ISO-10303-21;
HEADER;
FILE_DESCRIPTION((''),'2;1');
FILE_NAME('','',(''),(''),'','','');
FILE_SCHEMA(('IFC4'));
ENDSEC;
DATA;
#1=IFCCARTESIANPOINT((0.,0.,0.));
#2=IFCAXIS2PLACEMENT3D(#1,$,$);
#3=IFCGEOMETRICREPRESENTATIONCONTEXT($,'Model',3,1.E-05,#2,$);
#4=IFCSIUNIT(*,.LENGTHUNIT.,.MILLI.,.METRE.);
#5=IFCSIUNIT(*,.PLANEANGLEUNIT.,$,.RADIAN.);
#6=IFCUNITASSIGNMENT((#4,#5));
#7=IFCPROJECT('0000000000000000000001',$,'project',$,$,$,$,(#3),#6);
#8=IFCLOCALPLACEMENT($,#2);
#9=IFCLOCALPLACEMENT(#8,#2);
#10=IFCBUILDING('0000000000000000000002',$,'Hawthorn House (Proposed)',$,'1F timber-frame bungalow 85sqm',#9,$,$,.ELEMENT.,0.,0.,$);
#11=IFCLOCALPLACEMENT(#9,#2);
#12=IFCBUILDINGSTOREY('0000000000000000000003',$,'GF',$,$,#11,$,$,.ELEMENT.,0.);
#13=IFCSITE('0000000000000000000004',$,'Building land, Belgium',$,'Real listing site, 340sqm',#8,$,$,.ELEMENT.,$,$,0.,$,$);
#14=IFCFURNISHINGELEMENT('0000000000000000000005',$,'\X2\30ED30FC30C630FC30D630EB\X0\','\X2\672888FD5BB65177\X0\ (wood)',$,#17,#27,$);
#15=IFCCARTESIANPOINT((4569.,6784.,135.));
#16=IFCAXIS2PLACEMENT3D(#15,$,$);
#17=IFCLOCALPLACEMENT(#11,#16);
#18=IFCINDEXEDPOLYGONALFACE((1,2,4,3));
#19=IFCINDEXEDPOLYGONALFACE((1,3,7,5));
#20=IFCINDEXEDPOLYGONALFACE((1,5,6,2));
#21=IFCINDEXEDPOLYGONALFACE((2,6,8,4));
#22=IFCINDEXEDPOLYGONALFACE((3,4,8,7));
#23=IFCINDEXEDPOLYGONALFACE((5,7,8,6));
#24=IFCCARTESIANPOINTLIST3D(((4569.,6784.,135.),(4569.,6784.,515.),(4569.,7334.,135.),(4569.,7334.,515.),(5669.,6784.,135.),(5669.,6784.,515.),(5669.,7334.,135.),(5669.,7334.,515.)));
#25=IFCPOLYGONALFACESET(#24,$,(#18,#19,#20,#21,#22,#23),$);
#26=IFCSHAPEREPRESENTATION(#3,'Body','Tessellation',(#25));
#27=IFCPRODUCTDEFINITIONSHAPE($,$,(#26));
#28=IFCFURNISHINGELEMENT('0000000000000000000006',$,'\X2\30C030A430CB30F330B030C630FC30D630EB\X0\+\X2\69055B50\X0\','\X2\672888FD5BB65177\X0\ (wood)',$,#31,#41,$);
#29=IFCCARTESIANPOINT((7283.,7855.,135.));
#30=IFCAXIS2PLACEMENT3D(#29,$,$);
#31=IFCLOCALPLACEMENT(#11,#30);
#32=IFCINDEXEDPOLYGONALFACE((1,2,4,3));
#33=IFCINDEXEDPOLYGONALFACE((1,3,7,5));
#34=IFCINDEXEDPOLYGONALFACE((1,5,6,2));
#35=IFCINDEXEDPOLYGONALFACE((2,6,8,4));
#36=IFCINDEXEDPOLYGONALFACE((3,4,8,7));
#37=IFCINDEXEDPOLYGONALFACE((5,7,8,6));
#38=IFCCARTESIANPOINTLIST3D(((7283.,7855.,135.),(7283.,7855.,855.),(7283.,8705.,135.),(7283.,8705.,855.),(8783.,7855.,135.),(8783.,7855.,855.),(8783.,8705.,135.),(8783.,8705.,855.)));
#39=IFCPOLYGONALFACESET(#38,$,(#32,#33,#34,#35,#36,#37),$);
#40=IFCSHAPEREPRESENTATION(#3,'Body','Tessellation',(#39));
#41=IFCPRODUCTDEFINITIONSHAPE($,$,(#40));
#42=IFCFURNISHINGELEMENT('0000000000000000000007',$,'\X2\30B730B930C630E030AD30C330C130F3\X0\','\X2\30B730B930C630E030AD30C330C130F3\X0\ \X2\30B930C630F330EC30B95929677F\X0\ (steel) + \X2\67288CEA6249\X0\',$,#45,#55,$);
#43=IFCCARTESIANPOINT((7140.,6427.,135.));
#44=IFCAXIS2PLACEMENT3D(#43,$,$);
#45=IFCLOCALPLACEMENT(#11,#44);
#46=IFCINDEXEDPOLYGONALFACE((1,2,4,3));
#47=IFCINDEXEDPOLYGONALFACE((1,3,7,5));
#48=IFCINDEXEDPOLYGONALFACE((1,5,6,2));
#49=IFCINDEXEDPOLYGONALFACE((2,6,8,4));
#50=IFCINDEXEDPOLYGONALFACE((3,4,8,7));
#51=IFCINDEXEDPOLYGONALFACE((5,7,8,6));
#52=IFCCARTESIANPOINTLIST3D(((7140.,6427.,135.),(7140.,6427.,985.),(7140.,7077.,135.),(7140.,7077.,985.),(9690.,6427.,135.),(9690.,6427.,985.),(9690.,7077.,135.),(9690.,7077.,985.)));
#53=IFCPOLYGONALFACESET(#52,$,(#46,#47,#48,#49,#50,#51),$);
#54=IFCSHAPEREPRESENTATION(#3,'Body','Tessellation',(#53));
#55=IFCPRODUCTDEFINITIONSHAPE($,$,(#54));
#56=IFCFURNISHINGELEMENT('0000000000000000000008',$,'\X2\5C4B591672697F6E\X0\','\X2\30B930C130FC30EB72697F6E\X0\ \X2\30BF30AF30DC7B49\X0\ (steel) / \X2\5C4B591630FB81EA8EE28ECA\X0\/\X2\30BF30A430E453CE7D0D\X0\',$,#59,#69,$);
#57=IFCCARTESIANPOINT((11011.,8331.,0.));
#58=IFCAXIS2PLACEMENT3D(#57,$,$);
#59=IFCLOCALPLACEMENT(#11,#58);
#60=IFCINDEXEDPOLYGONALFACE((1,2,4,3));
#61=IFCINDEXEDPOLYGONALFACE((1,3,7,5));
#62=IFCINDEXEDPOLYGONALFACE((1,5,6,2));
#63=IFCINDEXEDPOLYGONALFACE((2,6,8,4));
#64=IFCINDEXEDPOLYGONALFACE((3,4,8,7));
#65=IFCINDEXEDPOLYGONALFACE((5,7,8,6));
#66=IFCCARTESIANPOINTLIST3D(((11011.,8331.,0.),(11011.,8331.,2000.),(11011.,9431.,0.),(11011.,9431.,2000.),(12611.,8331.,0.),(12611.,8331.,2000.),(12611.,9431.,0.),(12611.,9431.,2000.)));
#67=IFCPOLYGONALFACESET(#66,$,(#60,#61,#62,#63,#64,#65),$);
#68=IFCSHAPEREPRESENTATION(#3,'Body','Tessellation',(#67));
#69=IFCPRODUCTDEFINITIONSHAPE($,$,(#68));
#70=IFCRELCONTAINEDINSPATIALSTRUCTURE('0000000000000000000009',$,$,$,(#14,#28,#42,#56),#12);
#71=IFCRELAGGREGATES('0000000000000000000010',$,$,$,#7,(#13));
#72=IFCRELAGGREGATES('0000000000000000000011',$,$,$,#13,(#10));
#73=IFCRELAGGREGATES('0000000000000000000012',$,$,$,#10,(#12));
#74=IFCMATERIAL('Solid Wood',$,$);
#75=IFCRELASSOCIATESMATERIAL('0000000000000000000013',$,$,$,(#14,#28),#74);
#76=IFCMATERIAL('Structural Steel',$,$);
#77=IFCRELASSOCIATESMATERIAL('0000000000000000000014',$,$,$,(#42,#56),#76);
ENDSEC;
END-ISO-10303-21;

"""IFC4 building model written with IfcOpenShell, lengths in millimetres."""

from ifc_helpers import new_model, si_unit, frame, frame_2d, origin, place, context, project, spatial, rectangle, extrude, material, element, save


model = new_model("IFC4")

# Units and contexts
model_context = context("Model", 3, precision=1e-05, world=origin())
ifc_project = project(units=[si_unit("LENGTHUNIT", "METRE", prefix="MILLI"), si_unit("PLANEANGLEUNIT", "RADIAN")], contexts=[model_context])

# Site, building, storey
site_placement = place(None, origin())
site = spatial("IfcSite", under=ifc_project, at=site_placement, Name="Building land, Belgium", ObjectType="Real listing site, 340sqm", CompositionType="ELEMENT", RefElevation=0.0)
building_placement = place(site_placement, origin())
building = spatial("IfcBuilding", under=site, at=building_placement, Name="Hawthorn House (Proposed)", ObjectType="1F timber-frame bungalow 85sqm", CompositionType="ELEMENT", ElevationOfRefHeight=0.0, ElevationOfTerrain=0.0)
storey_placement = place(building_placement, origin())
storey = spatial("IfcBuildingStorey", under=building, at=storey_placement, Name="GF", CompositionType="ELEMENT", Elevation=0.0)

# Shared definitions
ifc_material_1 = material(Name="Solid Wood")

# Shared definitions
ifc_material_2 = material(Name="Structural Steel")

# Furnishing elements
furnishing_1_placement = place(storey_placement, frame((4569.0, 6784.0, 135.0)))
element("IfcFurnishingElement", 1, at=furnishing_1_placement, inside=storey, material=ifc_material_1, Name="ローテーブル", Description="木製家具 (wood)", context=model_context, shape_type="SweptSolid", body=[
    extrude(rectangle(XDim=1100.0, YDim=550.0, at=frame_2d((550.0, 275.0))), frame((4569.0, 6784.0, 135.0)), (0.0, 0.0, 1.0), 380.0),
])
furnishing_2_placement = place(storey_placement, frame((7283.0, 7855.0, 135.0)))
element("IfcFurnishingElement", 2, at=furnishing_2_placement, inside=storey, material=ifc_material_1, Name="ダイニングテーブル+椅子", Description="木製家具 (wood)", context=model_context, shape_type="SweptSolid", body=[
    extrude(rectangle(XDim=1500.0, YDim=850.0, at=frame_2d((750.0, 425.0))), frame((7283.0, 7855.0, 135.0)), (0.0, 0.0, 1.0), 720.0),
])
furnishing_3_placement = place(storey_placement, frame((7140.0, 6427.0, 135.0)))
element("IfcFurnishingElement", 3, at=furnishing_3_placement, inside=storey, material=ifc_material_2, Name="システムキッチン", Description="システムキッチン ステンレス天板 (steel) + 木質扉", context=model_context, shape_type="SweptSolid", body=[
    extrude(rectangle(XDim=2550.0, YDim=650.0, at=frame_2d((1275.0, 325.0))), frame((7140.0, 6427.0, 135.0)), (0.0, 0.0, 1.0), 850.0),
])
furnishing_4_placement = place(storey_placement, frame((11011.0, 8331.0, 0.0)))
element("IfcFurnishingElement", 4, at=furnishing_4_placement, inside=storey, material=ifc_material_2, Name="屋外物置", Description="スチール物置 タクボ等 (steel) / 屋外・自転車/タイヤ収納", context=model_context, shape_type="SweptSolid", body=[
    extrude(rectangle(XDim=1600.0, YDim=1100.0, at=frame_2d((800.0, 550.0))), frame((11011.0, 8331.0, 0.0)), (0.0, 0.0, 1.0), 2000.0),
])

save(model, "model.ifc")
